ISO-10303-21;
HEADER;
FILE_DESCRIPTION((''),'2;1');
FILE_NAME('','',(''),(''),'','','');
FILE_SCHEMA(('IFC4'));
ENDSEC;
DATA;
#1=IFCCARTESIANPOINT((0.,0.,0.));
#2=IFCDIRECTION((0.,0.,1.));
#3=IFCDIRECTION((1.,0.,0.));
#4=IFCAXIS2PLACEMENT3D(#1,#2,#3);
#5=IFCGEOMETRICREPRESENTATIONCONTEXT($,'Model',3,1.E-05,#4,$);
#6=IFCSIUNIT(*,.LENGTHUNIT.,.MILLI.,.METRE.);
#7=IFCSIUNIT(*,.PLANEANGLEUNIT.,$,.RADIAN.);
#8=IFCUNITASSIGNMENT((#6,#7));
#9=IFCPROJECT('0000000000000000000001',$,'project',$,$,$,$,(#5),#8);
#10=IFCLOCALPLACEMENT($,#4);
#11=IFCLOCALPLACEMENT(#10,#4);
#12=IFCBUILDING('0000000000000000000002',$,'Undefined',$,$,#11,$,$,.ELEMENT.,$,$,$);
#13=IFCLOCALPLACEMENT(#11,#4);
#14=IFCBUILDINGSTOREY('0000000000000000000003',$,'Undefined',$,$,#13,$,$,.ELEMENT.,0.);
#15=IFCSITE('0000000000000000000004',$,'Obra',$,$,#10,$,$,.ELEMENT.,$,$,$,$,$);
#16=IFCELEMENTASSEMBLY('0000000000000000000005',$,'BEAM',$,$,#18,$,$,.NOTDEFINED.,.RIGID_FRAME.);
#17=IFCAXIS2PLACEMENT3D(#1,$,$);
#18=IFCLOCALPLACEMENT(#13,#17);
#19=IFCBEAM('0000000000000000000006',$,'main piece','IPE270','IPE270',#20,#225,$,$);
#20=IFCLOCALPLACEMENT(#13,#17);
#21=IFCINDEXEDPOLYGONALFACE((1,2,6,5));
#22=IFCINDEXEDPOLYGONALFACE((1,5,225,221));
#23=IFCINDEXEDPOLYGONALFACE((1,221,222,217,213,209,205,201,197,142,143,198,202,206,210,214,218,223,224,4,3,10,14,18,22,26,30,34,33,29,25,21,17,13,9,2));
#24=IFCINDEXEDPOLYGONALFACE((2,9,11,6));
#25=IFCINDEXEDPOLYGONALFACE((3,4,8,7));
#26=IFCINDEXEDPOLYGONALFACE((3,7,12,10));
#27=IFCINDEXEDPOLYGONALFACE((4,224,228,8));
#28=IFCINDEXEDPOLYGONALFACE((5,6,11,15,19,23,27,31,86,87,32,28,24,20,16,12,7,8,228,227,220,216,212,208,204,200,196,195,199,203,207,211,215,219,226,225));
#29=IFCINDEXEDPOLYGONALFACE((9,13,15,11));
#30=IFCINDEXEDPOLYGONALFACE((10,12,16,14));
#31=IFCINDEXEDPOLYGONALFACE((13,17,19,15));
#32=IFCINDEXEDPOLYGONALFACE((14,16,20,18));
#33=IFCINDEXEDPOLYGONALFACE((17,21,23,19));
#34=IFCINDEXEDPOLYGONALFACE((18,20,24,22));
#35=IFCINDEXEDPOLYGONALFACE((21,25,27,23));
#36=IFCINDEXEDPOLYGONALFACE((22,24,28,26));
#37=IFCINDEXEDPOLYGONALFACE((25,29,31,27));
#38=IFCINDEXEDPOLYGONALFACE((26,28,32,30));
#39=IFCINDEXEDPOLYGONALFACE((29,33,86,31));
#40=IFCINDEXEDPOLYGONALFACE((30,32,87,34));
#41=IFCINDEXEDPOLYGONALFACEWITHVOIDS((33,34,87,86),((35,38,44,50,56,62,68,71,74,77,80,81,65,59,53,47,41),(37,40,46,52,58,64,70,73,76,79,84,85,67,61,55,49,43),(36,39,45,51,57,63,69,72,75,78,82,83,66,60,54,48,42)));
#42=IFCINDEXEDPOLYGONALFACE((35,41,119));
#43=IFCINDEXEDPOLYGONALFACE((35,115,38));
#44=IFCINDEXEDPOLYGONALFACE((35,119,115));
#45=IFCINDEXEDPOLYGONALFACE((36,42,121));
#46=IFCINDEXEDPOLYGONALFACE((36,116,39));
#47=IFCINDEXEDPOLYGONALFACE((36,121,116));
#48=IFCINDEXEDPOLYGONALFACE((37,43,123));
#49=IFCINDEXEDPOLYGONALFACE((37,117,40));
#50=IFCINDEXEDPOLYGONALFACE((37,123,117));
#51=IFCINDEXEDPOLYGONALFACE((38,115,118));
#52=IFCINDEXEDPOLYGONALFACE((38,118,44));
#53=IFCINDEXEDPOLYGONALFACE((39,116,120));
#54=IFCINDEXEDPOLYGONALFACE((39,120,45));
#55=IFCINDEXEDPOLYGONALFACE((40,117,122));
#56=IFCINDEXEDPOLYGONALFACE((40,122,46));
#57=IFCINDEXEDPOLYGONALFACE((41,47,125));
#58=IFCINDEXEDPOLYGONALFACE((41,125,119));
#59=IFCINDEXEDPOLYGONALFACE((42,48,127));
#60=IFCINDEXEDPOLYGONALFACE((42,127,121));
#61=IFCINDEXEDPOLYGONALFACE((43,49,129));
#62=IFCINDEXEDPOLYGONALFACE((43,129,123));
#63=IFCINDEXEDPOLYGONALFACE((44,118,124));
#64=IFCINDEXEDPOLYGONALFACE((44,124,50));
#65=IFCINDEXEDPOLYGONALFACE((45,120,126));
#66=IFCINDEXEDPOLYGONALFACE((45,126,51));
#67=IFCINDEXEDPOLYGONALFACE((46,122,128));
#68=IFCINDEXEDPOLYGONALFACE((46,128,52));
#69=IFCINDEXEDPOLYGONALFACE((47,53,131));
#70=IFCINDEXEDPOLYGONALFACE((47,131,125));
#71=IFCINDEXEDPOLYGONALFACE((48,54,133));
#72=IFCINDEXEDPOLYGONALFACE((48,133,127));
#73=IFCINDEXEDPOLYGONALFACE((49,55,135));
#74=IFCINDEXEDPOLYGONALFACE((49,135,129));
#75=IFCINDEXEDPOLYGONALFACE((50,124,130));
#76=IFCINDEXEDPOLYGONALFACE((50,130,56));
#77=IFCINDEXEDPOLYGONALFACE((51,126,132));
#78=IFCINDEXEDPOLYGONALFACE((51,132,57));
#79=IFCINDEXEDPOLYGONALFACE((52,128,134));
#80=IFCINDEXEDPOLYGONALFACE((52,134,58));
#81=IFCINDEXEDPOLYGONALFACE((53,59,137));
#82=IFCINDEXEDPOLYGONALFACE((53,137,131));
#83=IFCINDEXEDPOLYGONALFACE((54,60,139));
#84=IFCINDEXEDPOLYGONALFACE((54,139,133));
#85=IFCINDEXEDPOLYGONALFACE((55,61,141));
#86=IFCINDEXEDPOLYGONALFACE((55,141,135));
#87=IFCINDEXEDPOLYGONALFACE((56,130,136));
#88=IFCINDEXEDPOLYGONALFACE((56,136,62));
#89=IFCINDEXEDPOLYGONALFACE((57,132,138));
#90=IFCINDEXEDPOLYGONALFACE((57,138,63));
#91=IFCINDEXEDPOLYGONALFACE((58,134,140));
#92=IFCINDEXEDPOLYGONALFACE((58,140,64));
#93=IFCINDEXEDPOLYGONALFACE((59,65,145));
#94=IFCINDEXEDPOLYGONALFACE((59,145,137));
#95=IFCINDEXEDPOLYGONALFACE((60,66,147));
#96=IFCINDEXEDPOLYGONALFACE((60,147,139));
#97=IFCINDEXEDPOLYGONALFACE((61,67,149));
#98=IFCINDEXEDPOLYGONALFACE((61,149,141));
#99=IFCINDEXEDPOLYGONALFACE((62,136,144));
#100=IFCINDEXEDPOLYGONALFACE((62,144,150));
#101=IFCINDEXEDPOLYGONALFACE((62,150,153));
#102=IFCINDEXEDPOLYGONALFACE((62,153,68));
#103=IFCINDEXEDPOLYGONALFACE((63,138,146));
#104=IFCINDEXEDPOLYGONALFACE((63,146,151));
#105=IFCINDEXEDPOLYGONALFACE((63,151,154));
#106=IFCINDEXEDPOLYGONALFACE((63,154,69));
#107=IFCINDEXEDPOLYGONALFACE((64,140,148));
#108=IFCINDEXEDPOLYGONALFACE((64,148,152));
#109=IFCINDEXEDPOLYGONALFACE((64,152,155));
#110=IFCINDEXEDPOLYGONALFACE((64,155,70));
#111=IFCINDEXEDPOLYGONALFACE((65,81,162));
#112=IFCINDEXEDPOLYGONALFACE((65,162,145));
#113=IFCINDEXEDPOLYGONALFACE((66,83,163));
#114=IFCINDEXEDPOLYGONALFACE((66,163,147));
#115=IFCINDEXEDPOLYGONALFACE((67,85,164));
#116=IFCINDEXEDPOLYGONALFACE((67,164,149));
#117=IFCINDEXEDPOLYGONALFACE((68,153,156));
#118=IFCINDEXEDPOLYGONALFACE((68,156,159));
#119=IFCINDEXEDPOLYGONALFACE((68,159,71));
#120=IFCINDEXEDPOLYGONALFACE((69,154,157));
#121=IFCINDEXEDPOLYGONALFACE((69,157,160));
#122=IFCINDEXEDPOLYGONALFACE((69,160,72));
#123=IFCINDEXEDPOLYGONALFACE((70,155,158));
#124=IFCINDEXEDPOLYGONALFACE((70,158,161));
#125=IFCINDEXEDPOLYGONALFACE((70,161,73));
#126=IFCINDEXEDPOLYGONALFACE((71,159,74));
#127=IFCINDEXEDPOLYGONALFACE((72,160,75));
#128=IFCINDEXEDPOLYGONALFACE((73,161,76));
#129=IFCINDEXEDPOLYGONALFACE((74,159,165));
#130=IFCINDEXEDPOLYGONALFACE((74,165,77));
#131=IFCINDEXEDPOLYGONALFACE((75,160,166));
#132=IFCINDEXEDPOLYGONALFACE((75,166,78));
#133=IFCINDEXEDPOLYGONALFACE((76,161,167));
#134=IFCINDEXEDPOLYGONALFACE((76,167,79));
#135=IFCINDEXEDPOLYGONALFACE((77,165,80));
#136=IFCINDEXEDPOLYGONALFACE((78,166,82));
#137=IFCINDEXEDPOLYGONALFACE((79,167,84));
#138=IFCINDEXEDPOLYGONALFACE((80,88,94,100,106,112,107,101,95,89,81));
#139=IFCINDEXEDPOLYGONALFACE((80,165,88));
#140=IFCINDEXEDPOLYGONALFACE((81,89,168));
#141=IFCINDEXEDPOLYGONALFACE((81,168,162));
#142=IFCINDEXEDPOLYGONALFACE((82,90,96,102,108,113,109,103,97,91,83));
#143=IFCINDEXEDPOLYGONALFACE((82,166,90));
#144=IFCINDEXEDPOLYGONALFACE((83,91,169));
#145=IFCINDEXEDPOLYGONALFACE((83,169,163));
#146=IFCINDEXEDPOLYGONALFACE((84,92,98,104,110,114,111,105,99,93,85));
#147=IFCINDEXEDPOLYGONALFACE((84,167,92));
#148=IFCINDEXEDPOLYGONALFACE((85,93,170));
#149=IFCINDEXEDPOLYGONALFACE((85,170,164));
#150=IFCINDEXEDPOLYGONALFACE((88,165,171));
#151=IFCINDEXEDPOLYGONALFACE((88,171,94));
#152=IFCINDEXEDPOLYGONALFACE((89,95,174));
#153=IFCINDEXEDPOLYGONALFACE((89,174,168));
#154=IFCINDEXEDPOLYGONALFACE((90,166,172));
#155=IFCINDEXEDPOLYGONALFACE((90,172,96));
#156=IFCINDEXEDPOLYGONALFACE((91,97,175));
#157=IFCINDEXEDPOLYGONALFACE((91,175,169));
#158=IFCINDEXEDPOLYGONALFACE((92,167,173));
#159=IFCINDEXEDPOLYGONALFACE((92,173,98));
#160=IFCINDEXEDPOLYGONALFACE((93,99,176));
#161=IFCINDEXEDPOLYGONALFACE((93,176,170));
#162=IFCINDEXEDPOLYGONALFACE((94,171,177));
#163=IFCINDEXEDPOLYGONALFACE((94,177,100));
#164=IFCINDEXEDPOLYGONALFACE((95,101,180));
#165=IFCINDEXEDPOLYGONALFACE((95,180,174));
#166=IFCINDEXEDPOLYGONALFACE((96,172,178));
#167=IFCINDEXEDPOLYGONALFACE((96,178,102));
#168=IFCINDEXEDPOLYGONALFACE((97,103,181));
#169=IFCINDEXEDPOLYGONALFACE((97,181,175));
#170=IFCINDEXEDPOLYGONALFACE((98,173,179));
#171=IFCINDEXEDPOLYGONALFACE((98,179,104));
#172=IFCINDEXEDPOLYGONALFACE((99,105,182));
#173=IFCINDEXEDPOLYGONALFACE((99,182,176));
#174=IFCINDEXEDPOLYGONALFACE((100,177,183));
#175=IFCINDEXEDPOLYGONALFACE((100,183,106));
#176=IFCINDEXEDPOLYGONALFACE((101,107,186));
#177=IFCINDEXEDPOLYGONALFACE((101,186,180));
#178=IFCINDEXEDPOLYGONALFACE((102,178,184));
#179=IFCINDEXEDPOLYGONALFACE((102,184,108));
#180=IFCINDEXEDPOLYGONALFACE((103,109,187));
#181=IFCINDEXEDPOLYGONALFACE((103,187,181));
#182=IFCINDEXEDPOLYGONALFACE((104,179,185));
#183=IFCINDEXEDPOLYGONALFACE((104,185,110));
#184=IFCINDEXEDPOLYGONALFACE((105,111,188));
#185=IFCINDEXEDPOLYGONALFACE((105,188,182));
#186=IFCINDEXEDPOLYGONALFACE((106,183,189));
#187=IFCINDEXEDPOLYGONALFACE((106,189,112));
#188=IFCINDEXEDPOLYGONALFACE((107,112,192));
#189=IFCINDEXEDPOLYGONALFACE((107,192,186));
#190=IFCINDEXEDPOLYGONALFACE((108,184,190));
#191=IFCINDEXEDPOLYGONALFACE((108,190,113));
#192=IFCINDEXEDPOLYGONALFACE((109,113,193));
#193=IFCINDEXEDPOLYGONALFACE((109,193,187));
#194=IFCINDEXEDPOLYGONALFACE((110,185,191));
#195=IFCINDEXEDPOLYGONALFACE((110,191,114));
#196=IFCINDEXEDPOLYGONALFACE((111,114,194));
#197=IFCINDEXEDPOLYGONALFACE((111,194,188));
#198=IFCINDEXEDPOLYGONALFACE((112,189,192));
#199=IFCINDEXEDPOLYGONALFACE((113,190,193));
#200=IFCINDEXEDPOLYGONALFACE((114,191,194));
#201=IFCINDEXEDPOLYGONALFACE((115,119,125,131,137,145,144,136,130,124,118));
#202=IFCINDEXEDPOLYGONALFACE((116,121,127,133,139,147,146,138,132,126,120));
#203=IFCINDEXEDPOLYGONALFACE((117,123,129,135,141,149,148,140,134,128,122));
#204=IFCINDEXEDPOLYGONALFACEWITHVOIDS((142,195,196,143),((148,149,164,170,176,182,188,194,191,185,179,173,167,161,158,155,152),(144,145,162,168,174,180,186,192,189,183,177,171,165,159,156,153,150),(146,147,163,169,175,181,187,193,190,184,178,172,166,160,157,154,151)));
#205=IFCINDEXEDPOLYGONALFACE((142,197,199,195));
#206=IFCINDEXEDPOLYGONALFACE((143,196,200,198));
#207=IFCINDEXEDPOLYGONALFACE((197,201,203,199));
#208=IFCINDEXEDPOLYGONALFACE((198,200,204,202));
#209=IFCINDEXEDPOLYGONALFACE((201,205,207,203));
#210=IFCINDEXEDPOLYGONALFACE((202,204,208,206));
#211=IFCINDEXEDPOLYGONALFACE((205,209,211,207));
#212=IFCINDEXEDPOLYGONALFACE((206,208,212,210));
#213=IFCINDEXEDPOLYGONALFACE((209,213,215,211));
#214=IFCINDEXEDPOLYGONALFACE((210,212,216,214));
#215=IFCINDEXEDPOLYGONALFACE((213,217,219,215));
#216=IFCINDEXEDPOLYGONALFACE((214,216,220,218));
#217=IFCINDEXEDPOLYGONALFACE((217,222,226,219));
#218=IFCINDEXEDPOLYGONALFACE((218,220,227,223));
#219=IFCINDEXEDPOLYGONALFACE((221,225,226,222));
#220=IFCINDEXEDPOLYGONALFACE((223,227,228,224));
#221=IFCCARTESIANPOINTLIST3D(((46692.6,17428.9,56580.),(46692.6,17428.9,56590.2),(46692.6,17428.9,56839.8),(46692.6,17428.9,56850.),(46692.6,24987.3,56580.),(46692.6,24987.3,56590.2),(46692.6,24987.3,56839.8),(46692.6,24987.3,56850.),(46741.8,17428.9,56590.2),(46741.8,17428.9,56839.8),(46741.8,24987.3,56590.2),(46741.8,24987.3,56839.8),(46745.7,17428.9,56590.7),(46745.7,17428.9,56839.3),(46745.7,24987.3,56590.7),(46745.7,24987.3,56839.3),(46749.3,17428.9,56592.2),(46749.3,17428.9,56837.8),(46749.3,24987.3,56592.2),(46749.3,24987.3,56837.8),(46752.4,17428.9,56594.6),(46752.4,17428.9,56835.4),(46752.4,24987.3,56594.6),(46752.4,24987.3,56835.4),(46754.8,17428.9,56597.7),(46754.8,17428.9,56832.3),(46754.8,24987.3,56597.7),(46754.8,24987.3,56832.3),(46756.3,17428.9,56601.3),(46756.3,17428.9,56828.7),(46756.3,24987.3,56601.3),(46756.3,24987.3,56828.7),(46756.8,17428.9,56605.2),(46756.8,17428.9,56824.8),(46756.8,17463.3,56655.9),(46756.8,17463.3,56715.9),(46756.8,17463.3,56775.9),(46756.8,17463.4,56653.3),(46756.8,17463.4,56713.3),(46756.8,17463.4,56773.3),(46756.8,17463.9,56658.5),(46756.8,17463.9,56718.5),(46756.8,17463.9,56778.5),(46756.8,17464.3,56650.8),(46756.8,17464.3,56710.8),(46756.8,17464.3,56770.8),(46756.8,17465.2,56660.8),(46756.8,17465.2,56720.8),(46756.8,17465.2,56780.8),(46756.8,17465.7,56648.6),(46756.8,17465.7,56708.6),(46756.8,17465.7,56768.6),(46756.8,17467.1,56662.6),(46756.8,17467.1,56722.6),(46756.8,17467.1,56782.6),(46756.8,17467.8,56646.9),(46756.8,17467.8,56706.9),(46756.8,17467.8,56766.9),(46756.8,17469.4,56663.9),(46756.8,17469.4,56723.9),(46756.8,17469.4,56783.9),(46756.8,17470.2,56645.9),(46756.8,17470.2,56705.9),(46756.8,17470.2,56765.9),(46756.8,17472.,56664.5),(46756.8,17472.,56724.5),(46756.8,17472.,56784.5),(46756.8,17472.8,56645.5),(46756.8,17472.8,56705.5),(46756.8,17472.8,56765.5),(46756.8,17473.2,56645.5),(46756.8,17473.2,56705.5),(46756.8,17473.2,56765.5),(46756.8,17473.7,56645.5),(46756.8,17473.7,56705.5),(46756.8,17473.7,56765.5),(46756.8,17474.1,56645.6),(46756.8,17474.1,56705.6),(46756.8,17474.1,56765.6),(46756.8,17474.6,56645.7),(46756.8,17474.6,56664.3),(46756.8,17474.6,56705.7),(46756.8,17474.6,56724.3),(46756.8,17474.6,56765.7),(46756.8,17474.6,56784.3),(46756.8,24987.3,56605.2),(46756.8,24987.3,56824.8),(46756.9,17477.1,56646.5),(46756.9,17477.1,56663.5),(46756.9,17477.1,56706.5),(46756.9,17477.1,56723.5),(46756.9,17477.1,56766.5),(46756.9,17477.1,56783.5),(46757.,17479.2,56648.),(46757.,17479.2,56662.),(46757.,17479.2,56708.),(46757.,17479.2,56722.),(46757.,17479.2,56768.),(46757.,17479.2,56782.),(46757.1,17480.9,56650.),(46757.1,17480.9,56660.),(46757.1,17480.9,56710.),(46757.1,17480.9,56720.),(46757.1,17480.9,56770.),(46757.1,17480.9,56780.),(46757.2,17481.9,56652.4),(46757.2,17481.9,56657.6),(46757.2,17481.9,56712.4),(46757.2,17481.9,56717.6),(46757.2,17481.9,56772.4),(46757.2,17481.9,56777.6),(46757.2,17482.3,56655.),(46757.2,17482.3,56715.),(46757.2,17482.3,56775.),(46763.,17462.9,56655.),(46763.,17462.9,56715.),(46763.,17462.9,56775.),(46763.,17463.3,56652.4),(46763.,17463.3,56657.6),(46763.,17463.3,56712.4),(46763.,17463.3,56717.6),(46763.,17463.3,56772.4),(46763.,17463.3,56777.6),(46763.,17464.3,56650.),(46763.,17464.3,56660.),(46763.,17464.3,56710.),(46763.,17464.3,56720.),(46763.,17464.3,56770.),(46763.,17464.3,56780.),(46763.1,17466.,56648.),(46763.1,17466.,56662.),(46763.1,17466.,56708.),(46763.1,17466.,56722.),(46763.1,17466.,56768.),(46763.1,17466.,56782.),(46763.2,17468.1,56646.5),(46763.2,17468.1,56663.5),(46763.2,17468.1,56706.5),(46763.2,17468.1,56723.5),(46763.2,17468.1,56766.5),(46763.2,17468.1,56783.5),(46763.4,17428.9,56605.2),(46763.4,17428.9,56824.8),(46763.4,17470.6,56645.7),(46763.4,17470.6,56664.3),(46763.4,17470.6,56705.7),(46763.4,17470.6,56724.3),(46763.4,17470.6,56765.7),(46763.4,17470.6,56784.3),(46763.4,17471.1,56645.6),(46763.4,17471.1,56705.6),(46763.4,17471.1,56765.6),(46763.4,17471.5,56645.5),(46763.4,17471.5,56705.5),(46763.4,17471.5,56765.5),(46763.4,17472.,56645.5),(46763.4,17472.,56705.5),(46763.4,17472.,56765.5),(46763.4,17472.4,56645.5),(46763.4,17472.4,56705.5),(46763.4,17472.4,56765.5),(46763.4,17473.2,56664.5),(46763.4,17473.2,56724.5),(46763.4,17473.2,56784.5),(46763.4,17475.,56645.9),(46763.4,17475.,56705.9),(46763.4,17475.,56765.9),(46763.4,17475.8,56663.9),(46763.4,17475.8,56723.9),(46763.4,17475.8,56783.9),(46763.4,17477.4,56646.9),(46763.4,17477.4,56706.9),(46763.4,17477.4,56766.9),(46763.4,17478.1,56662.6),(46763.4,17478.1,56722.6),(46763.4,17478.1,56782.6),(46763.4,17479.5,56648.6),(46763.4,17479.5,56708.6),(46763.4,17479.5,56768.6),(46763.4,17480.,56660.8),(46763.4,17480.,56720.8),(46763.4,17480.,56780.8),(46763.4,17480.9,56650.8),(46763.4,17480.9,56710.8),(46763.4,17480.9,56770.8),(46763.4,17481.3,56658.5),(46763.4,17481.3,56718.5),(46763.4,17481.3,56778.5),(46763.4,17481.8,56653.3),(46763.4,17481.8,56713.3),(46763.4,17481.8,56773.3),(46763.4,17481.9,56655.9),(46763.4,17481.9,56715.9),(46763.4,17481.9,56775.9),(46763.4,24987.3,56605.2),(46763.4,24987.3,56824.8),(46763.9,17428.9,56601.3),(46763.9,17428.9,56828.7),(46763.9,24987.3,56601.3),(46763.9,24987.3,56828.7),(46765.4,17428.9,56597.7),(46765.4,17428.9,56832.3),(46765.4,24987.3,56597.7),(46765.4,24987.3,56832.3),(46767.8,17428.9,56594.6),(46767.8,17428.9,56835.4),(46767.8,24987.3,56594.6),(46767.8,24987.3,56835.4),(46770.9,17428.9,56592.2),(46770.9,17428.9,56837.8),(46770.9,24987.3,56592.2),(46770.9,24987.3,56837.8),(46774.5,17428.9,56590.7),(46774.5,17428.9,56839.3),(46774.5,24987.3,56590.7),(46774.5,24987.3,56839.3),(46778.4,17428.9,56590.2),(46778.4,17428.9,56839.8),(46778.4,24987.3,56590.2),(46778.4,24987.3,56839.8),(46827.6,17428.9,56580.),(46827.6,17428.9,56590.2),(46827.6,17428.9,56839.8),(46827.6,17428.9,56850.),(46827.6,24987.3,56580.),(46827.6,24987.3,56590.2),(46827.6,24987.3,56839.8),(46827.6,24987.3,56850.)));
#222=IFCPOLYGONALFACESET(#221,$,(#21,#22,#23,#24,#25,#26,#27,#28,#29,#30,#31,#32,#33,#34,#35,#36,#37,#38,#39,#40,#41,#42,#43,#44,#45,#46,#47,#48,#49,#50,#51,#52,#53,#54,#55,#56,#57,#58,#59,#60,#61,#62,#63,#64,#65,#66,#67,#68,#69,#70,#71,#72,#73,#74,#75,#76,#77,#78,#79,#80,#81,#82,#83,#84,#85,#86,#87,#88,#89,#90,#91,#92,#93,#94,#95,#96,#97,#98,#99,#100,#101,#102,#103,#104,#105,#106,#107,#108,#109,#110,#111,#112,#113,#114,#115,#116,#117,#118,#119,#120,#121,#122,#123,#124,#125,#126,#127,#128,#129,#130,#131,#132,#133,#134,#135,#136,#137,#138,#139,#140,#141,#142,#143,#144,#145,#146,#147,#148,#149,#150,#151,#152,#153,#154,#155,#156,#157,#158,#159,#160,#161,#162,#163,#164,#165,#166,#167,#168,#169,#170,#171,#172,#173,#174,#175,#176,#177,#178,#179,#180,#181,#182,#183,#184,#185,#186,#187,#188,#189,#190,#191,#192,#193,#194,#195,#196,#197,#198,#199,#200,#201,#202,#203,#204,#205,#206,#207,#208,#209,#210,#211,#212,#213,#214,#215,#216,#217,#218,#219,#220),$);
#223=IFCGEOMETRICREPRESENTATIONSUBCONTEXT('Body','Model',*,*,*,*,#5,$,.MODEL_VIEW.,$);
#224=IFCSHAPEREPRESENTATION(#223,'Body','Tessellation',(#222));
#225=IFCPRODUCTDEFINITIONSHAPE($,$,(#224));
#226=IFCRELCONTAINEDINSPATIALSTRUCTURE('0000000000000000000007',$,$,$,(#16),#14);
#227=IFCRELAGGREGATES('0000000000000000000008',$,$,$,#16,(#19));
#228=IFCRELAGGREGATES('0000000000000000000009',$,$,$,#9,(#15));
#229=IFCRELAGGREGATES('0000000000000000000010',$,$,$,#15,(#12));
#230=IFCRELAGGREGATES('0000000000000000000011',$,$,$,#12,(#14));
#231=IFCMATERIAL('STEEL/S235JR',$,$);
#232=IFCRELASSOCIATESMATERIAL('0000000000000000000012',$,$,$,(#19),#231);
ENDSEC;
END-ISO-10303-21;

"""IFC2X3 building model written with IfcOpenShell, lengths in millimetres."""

from ifc_helpers import new_model, si_unit, frame, origin_with_axes, origin_2d_with_axis, place, context, subcontext, project, spatial, circle, i_section, extrude, clip, halfspace, source, transform, mapped, material, element, aggregate, save


model = new_model("IFC2X3")

# Units and contexts
model_context = context("Model", 3, precision=1e-05, world=origin_with_axes())
body_context = subcontext(model_context, "Body", "Model", "MODEL_VIEW")
ifc_project = project(units=[si_unit("LENGTHUNIT", "METRE", prefix="MILLI"), si_unit("PLANEANGLEUNIT", "RADIAN")], contexts=[model_context])

# Site, building, storey
site_placement = place(None, origin_with_axes())
site = spatial("IfcSite", under=ifc_project, at=site_placement, Name="Obra", CompositionType="ELEMENT")
building_placement = place(site_placement, origin_with_axes())
building = spatial("IfcBuilding", under=site, at=building_placement, Name="Undefined", CompositionType="ELEMENT")
storey_placement = place(building_placement, origin_with_axes())
storey = spatial("IfcBuildingStorey", under=building, at=storey_placement, Name="Undefined", CompositionType="ELEMENT", Elevation=0.0)

# Shared definitions
ifc_material_1 = material(Name="STEEL/S235JR")

# Element assembly, beam, opening
assembly_1_placement = place(storey_placement, origin_with_axes())
assembly_1 = element("IfcElementAssembly", 1, at=assembly_1_placement, inside=storey, Name="BEAM", AssemblyPlace="NOTDEFINED", PredefinedType="RIGID_FRAME")
beam_1_placement = place(assembly_1_placement, frame((46760.1, 24987.3, 56715.0), z_axis=(0.0, 0.0, 1.0), x_axis=(0.0, -1.0, 0.0)))
beam_1 = element("IfcBeam", 2, at=beam_1_placement, material=ifc_material_1, Name="main piece", Description="IPE270", ObjectType="IPE270", context=body_context, shape_type="Clipping", body=[
    clip(extrude(i_section(OverallWidth=135.0, OverallDepth=270.0, WebThickness=6.6, FlangeThickness=10.2, FilletRadius=15.0, at=origin_2d_with_axis()), frame((7558.4, 0.0, 0.0), z_axis=(-1.0, 0.0, 0.0), x_axis=(0.0, -1.0, 0.0)), (0.0, 0.0, 1.0), 7558.4), halfspace(frame((7562.6, -31.7, -120.0), z_axis=(0.998473, -0.055249, 0.0), x_axis=(0.0, 0.0, 1.0)), False)),
])
shared_shape_1 = source(origin_with_axes(), body_context, "Body", "SweptSolid", [
    extrude(circle(Radius=9.5, at=origin_2d_with_axis()), frame((0.0, 27.6, 0.0), z_axis=(0.0, 1.0, 0.0), x_axis=(1.0, 0.0, 0.0)), (0.0, 0.0, 1.0), 6.8),
])
opening_1_placement = place(assembly_1_placement, frame((46788.3, 17421.0, 56835.0), z_axis=(0.055268, 0.998472, 0.0), x_axis=(0.0, 0.0, -1.0)))
element("IfcOpeningElement", 3, at=opening_1_placement, cuts=beam_1, ObjectType="Opening", context=body_context, shape_type="MappedRepresentation", body=[
    mapped(shared_shape_1, transform((60.0, 0.0, 50.0))),
    mapped(shared_shape_1, transform((120.0, 0.0, 50.0))),
    mapped(shared_shape_1, transform((180.0, 0.0, 50.0))),
])
aggregate(assembly_1, [beam_1])

save(model, "model.ifc")
